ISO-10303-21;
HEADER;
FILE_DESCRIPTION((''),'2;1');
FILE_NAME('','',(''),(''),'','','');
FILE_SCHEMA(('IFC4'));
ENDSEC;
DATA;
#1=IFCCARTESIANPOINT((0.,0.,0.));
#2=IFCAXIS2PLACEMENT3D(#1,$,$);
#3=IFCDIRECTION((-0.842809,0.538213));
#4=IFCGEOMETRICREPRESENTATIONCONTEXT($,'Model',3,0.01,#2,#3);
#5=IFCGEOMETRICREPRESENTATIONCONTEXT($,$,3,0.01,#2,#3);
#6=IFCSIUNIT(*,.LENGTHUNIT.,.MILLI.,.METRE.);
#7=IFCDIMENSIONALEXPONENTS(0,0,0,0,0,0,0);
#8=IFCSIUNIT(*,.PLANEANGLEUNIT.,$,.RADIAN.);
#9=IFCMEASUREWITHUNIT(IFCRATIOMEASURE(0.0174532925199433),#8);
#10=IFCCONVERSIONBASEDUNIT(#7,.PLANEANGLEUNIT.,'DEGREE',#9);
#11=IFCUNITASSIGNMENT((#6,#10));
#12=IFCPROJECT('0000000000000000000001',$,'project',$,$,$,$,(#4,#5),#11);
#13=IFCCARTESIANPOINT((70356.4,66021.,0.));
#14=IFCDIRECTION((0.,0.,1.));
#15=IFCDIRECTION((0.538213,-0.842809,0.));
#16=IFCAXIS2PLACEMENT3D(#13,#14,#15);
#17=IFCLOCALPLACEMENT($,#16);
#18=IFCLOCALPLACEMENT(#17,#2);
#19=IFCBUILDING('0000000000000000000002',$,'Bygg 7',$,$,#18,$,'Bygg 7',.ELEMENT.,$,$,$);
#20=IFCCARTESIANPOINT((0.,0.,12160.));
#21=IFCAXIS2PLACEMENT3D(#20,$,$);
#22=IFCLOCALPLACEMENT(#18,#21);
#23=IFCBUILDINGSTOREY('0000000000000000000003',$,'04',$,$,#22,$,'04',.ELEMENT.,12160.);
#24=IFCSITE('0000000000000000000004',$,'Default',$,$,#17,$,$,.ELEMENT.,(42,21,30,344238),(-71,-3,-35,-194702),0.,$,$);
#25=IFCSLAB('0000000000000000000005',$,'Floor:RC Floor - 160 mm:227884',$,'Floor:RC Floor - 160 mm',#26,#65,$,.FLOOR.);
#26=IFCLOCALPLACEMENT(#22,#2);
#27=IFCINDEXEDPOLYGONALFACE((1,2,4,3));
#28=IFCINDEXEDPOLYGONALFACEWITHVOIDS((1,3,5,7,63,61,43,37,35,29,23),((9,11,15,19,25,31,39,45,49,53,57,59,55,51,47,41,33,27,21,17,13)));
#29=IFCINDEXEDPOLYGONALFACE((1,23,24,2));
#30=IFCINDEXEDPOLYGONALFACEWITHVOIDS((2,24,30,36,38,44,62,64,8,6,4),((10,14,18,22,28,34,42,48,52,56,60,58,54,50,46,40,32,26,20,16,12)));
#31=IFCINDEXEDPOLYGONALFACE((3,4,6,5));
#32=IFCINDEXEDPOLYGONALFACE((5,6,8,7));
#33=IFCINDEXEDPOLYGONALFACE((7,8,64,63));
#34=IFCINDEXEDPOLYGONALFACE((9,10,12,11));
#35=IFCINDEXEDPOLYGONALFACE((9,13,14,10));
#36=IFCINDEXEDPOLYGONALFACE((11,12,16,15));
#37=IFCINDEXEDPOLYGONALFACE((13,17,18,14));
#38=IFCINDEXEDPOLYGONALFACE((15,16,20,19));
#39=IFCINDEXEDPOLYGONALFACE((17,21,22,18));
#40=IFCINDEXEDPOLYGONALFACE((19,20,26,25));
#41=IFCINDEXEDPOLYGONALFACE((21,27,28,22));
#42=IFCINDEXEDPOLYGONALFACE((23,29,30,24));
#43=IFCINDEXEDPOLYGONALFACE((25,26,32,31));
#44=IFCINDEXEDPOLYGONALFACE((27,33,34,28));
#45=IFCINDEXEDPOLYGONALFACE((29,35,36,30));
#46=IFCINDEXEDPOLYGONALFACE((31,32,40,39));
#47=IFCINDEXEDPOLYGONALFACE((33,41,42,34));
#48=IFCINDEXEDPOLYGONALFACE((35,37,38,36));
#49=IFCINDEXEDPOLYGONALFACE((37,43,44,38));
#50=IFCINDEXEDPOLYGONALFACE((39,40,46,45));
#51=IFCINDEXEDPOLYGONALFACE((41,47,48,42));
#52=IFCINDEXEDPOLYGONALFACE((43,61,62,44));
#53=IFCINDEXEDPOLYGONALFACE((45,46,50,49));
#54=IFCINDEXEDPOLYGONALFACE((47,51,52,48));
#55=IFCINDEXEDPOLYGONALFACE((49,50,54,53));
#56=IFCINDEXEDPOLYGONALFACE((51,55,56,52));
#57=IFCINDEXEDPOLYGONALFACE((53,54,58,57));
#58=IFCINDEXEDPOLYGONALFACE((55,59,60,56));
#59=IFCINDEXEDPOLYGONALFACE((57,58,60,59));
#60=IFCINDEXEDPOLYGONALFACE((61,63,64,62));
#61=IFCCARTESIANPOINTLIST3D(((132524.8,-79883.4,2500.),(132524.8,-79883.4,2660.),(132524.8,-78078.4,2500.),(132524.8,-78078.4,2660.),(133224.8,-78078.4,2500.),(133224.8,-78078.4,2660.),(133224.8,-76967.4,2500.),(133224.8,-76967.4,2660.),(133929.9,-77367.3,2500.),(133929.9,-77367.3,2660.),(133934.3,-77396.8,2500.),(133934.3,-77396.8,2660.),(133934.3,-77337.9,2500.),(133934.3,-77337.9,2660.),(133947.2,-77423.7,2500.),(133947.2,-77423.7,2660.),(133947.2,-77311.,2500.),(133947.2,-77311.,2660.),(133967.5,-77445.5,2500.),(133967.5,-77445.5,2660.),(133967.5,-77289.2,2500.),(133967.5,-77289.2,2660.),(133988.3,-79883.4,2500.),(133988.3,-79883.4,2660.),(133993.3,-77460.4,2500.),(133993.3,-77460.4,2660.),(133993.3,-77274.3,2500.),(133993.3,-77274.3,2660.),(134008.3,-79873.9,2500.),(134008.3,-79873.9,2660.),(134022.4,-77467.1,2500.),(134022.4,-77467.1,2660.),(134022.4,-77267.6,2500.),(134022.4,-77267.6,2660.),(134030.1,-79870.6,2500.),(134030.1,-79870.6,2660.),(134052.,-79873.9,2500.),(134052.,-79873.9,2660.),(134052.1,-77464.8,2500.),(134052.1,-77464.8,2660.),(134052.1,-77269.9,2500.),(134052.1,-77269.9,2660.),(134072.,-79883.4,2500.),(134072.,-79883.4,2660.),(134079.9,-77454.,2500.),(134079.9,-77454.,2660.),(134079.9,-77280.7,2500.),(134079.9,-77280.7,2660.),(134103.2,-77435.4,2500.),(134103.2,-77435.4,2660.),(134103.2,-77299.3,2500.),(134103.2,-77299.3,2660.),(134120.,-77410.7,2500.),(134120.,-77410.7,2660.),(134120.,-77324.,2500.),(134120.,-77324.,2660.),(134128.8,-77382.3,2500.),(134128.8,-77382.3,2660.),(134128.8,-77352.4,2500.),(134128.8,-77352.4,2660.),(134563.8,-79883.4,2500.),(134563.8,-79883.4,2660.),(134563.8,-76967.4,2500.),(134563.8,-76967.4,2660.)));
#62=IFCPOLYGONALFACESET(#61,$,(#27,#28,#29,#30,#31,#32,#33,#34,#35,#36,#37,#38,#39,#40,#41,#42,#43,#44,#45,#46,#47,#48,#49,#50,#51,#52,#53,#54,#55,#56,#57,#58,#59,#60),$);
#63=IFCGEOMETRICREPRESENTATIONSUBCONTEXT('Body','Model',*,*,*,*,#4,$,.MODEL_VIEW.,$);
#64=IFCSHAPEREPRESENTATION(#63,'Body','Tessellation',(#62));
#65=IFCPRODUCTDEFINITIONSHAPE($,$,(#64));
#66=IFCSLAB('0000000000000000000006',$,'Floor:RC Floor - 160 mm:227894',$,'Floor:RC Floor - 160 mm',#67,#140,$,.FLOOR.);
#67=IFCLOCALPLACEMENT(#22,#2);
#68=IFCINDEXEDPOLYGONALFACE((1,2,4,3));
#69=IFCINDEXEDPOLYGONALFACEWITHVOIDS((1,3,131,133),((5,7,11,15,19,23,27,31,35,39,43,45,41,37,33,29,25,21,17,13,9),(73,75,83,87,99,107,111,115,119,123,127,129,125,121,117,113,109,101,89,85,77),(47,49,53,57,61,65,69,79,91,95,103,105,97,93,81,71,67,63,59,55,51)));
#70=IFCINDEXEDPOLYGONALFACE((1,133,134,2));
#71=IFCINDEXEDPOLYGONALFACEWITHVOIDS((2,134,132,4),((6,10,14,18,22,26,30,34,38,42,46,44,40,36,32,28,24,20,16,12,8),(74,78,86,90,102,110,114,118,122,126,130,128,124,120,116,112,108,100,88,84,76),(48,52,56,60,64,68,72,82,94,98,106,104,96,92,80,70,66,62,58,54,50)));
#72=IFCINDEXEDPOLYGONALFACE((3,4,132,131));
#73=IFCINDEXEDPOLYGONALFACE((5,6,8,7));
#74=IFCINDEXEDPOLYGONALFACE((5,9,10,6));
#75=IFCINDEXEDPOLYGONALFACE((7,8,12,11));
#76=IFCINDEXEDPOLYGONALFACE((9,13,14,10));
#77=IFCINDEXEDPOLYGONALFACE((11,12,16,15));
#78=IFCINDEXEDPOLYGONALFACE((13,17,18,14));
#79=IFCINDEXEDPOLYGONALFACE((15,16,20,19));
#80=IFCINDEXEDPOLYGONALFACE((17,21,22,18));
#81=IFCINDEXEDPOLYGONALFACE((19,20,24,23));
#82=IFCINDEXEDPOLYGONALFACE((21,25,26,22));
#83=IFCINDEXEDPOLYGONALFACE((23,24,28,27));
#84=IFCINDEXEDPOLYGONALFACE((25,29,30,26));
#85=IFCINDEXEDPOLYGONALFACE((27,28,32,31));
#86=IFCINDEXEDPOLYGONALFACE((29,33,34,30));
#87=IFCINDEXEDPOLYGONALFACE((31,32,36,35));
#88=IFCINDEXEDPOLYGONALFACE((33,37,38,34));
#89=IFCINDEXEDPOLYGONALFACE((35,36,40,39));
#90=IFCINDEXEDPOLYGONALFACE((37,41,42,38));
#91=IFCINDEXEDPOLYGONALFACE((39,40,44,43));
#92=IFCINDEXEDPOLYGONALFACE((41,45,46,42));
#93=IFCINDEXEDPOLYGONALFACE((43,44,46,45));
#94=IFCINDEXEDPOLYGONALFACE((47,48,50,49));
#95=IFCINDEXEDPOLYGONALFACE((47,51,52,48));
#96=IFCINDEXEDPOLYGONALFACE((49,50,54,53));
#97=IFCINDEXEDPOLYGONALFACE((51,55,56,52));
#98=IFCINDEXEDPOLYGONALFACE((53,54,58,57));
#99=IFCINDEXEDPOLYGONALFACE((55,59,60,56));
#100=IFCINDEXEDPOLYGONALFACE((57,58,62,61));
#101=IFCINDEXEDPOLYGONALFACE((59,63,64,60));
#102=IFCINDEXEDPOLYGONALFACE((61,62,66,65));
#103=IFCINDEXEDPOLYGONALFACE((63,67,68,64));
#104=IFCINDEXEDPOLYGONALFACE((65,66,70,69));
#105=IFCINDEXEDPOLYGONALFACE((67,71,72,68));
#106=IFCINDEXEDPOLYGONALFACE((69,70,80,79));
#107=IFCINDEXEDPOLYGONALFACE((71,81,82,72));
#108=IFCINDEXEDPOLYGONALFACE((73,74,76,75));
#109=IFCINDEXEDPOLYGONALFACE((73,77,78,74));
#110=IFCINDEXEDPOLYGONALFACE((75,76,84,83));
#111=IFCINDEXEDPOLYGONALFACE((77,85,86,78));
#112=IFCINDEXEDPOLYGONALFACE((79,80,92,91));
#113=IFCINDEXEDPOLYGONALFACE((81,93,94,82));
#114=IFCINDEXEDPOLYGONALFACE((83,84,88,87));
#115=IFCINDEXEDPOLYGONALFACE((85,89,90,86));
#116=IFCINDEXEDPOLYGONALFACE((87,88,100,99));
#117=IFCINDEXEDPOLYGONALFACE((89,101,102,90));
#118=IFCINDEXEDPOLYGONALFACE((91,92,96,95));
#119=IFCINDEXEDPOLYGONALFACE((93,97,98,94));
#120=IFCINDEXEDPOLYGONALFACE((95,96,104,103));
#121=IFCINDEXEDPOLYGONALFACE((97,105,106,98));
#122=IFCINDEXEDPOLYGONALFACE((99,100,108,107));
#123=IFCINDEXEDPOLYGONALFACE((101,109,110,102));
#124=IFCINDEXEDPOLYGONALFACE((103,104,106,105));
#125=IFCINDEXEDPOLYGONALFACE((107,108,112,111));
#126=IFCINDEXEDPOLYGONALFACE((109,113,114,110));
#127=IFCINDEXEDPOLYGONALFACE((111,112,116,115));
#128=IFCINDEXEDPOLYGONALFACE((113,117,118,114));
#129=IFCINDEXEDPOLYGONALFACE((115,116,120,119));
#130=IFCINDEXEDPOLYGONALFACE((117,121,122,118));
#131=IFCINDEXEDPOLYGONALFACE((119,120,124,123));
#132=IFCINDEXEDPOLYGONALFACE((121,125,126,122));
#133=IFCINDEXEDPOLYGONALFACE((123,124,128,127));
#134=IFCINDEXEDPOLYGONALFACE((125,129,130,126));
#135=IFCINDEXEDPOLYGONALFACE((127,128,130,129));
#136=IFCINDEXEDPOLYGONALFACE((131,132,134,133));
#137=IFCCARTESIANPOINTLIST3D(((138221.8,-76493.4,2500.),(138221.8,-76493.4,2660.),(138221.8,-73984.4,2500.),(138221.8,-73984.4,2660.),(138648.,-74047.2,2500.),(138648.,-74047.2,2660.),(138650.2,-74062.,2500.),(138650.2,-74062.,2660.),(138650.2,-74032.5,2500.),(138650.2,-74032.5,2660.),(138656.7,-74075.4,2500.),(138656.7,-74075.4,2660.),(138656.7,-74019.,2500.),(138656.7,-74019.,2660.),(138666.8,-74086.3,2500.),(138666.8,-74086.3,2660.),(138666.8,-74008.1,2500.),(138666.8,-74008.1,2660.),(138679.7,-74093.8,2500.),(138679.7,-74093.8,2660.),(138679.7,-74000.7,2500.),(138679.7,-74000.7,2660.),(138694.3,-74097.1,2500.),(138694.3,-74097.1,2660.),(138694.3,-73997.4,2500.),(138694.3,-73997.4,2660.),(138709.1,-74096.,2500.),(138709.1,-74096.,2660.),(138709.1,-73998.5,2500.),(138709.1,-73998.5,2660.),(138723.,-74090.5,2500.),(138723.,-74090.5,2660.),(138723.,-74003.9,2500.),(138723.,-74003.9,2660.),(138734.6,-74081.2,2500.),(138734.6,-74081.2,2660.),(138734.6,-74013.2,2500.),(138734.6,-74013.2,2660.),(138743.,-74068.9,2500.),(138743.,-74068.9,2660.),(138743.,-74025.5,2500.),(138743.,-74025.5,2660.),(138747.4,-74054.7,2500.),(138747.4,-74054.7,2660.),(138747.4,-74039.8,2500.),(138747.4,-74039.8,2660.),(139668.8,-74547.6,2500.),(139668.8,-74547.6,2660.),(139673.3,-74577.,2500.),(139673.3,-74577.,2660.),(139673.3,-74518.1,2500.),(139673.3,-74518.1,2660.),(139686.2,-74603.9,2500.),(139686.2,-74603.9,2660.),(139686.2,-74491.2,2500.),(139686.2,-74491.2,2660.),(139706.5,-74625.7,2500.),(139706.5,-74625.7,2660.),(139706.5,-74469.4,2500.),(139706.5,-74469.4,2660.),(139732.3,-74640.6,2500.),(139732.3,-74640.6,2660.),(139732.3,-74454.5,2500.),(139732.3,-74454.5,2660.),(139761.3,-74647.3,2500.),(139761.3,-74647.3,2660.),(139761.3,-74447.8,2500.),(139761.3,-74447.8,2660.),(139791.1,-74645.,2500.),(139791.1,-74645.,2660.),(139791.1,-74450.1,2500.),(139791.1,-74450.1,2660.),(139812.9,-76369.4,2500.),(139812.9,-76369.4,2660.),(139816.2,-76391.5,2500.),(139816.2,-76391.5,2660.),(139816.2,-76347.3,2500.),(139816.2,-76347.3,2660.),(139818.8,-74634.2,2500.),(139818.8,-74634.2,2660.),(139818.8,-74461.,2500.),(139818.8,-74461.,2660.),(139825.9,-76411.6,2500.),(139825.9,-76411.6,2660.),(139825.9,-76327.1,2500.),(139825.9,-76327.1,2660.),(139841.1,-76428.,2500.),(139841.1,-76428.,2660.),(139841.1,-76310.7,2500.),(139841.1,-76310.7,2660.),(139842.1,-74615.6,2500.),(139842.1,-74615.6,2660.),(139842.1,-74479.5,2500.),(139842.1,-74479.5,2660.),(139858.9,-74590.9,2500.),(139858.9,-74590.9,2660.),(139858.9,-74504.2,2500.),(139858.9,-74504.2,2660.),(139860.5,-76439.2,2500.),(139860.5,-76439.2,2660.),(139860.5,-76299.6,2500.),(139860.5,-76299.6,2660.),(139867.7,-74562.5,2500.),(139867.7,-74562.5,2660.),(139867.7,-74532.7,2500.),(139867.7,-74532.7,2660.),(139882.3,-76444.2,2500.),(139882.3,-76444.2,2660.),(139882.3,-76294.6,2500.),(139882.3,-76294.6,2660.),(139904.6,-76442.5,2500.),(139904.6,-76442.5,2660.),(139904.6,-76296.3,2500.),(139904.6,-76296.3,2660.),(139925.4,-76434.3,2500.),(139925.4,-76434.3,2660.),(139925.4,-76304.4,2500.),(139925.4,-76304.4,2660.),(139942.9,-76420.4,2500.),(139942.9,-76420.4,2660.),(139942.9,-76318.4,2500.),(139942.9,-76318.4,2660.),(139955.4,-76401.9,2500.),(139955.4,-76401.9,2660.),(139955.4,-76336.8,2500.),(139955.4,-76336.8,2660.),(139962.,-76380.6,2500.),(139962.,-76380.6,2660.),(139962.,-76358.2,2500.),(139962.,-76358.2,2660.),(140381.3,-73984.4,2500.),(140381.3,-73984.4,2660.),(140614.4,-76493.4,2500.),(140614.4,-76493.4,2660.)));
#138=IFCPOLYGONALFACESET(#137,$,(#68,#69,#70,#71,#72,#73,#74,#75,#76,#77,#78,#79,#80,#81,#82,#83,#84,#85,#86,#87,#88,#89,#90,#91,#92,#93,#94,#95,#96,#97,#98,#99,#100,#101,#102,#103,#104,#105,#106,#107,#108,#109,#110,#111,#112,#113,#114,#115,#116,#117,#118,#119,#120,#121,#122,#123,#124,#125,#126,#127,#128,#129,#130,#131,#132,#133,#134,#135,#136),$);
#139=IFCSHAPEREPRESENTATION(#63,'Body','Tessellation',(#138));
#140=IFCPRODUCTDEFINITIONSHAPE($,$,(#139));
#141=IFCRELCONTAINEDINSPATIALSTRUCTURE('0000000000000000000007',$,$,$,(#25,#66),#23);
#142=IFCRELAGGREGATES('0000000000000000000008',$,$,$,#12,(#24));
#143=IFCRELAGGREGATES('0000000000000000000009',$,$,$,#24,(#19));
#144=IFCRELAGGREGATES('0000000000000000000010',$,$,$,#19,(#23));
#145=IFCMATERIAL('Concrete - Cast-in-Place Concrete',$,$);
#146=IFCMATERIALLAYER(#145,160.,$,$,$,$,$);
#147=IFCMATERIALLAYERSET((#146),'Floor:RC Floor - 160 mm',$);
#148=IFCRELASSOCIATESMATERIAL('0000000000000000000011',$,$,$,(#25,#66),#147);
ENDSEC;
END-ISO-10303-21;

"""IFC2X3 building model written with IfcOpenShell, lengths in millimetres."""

from ifc_helpers import new_model, entity, si_unit, converted_unit, direction, frame, frame_2d, origin, place, context, subcontext, project, spatial, polyline, circle, outline, extrude, material, layer, layer_set, layer_usage, element, save


model = new_model("IFC2X3")

# Units and contexts
model_context = context("Model", 3, precision=0.01, world=origin(), true_north=direction((-0.842809, 0.538213)))
context_of_model = context(None, 3, precision=0.01, world=origin(), true_north=direction((-0.842809, 0.538213)))
body_context = subcontext(model_context, "Body", "Model", "MODEL_VIEW")
ifc_project = project(units=[si_unit("LENGTHUNIT", "METRE", prefix="MILLI"), converted_unit("PLANEANGLEUNIT", "DEGREE", entity("IfcRatioMeasure", 0.0174532925199433), si_unit("PLANEANGLEUNIT", "RADIAN"), dimensions=[0, 0, 0, 0, 0, 0, 0])], contexts=[model_context, context_of_model])

# Site, building, storey
site_placement = place(None, frame((70356.4, 66021.0, 0.0), z_axis=(0.0, 0.0, 1.0), x_axis=(0.538213, -0.842809, 0.0)))
site = spatial("IfcSite", under=ifc_project, at=site_placement, Name="Default", CompositionType="ELEMENT", RefLatitude=(42, 21, 30, 344238), RefLongitude=(-71, -3, -35, -194702), RefElevation=0.0)
building_placement = place(site_placement, origin())
building = spatial("IfcBuilding", under=site, at=building_placement, Name="Bygg 7", LongName="Bygg 7", CompositionType="ELEMENT")
storey_placement = place(building_placement, frame((0.0, 0.0, 12160.0)))
storey = spatial("IfcBuildingStorey", under=building, at=storey_placement, Name="04", LongName="04", CompositionType="ELEMENT", Elevation=12160.0)

# Slabs, openings
ifc_material_1 = material(Name="Concrete - Cast-in-Place Concrete")
ifc_layer_1 = layer(ifc_material_1, 160.0)
ifc_layer_set_1 = layer_set([ifc_layer_1], Name="Floor:RC Floor - 160 mm")
ifc_layer_usage_1 = layer_usage(ifc_layer_set_1, "AXIS3", "POSITIVE", 0.0)
slab_1_placement = place(storey_placement, frame((132524.8, -79883.4, 2500.0)))
slab_1 = element("IfcSlab", 1, at=slab_1_placement, inside=storey, material=ifc_layer_usage_1, Name="Floor:RC Floor - 160 mm:227884", ObjectType="Floor:RC Floor - 160 mm", PredefinedType="FLOOR", context=body_context, shape_type="SweptSolid", body=[
    extrude(outline(polyline([(1019.5, 347.0), (319.5, 347.0), (319.5, 1458.0), (-1019.5, 1458.0), (-1019.5, -1458.0), (1019.5, -1458.0), (1019.5, 347.0)])), frame((1019.5, 1458.0, 160.0), z_axis=(0.0, 0.0, -1.0), x_axis=(-1.0, 0.0, 0.0)), (0.0, 0.0, 1.0), 160.0),
])
opening_1_placement = place(storey_placement, frame((132524.8, -79883.4, 2500.0)))
element("IfcOpeningElement", 2, at=opening_1_placement, cuts=slab_1, ObjectType="Opening", context=body_context, shape_type="SweptSolid", body=[
    extrude(circle(Radius=100.0, at=frame_2d((-485.5, 1058.0), x_axis=(1.0, 0.0))), frame((1019.5, 1458.0, 160.0), z_axis=(0.0, 0.0, -1.0), x_axis=(-1.0, 0.0, 0.0)), (0.0, 0.0, 1.0), 160.0),
])
opening_2_placement = place(storey_placement, frame((132524.8, -79883.4, 2500.0)))
element("IfcOpeningElement", 3, at=opening_2_placement, cuts=slab_1, ObjectType="Opening", context=body_context, shape_type="SweptSolid", body=[
    extrude(circle(Radius=75.0, at=frame_2d((-485.8, -1520.2), x_axis=(1.0, 0.0))), frame((1019.5, 1458.0, 160.0), z_axis=(0.0, 0.0, -1.0), x_axis=(-1.0, 0.0, 0.0)), (0.0, 0.0, 1.0), 160.0),
])
ifc_layer_usage_2 = layer_usage(ifc_layer_set_1, "AXIS3", "POSITIVE", 0.0)
slab_2_placement = place(storey_placement, frame((138221.8, -76493.4, 2500.0)))
slab_2 = element("IfcSlab", 4, at=slab_2_placement, inside=storey, material=ifc_layer_usage_2, Name="Floor:RC Floor - 160 mm:227894", ObjectType="Floor:RC Floor - 160 mm", PredefinedType="FLOOR", context=body_context, shape_type="SweptSolid", body=[
    extrude(outline(polyline([(1196.3, -1254.5), (1196.3, 1254.5), (-963.1, 1254.5), (-1196.3, -1254.5), (1196.3, -1254.5)])), frame((1196.3, 1254.5, 160.0), z_axis=(0.0, 0.0, -1.0), x_axis=(-1.0, 0.0, 0.0)), (0.0, 0.0, 1.0), 160.0),
])
opening_3_placement = place(storey_placement, frame((138221.8, -76493.4, 2500.0)))
element("IfcOpeningElement", 5, at=opening_3_placement, cuts=slab_2, ObjectType="Opening", context=body_context, shape_type="SweptSolid", body=[
    extrude(circle(Radius=75.0, at=frame_2d((-469.7, -1130.5), x_axis=(1.0, 0.0))), frame((1196.3, 1254.5, 160.0), z_axis=(0.0, 0.0, -1.0), x_axis=(-1.0, 0.0, 0.0)), (0.0, 0.0, 1.0), 160.0),
])
opening_4_placement = place(storey_placement, frame((138221.8, -76493.4, 2500.0)))
element("IfcOpeningElement", 6, at=opening_4_placement, cuts=slab_2, ObjectType="Opening", context=body_context, shape_type="SweptSolid", body=[
    extrude(circle(Radius=100.0, at=frame_2d((-350.7, 691.3), x_axis=(1.0, 0.0))), frame((1196.3, 1254.5, 160.0), z_axis=(0.0, 0.0, -1.0), x_axis=(-1.0, 0.0, 0.0)), (0.0, 0.0, 1.0), 160.0),
])
opening_5_placement = place(storey_placement, frame((138221.8, -76493.4, 2500.0)))
element("IfcOpeningElement", 7, at=opening_5_placement, cuts=slab_2, ObjectType="Opening", context=body_context, shape_type="SweptSolid", body=[
    extrude(circle(Radius=50.0, at=frame_2d((720.1, 1191.6), x_axis=(1.0, 0.0))), frame((1196.3, 1254.5, 160.0), z_axis=(0.0, 0.0, -1.0), x_axis=(-1.0, 0.0, 0.0)), (0.0, 0.0, 1.0), 160.0),
])

save(model, "model.ifc")
